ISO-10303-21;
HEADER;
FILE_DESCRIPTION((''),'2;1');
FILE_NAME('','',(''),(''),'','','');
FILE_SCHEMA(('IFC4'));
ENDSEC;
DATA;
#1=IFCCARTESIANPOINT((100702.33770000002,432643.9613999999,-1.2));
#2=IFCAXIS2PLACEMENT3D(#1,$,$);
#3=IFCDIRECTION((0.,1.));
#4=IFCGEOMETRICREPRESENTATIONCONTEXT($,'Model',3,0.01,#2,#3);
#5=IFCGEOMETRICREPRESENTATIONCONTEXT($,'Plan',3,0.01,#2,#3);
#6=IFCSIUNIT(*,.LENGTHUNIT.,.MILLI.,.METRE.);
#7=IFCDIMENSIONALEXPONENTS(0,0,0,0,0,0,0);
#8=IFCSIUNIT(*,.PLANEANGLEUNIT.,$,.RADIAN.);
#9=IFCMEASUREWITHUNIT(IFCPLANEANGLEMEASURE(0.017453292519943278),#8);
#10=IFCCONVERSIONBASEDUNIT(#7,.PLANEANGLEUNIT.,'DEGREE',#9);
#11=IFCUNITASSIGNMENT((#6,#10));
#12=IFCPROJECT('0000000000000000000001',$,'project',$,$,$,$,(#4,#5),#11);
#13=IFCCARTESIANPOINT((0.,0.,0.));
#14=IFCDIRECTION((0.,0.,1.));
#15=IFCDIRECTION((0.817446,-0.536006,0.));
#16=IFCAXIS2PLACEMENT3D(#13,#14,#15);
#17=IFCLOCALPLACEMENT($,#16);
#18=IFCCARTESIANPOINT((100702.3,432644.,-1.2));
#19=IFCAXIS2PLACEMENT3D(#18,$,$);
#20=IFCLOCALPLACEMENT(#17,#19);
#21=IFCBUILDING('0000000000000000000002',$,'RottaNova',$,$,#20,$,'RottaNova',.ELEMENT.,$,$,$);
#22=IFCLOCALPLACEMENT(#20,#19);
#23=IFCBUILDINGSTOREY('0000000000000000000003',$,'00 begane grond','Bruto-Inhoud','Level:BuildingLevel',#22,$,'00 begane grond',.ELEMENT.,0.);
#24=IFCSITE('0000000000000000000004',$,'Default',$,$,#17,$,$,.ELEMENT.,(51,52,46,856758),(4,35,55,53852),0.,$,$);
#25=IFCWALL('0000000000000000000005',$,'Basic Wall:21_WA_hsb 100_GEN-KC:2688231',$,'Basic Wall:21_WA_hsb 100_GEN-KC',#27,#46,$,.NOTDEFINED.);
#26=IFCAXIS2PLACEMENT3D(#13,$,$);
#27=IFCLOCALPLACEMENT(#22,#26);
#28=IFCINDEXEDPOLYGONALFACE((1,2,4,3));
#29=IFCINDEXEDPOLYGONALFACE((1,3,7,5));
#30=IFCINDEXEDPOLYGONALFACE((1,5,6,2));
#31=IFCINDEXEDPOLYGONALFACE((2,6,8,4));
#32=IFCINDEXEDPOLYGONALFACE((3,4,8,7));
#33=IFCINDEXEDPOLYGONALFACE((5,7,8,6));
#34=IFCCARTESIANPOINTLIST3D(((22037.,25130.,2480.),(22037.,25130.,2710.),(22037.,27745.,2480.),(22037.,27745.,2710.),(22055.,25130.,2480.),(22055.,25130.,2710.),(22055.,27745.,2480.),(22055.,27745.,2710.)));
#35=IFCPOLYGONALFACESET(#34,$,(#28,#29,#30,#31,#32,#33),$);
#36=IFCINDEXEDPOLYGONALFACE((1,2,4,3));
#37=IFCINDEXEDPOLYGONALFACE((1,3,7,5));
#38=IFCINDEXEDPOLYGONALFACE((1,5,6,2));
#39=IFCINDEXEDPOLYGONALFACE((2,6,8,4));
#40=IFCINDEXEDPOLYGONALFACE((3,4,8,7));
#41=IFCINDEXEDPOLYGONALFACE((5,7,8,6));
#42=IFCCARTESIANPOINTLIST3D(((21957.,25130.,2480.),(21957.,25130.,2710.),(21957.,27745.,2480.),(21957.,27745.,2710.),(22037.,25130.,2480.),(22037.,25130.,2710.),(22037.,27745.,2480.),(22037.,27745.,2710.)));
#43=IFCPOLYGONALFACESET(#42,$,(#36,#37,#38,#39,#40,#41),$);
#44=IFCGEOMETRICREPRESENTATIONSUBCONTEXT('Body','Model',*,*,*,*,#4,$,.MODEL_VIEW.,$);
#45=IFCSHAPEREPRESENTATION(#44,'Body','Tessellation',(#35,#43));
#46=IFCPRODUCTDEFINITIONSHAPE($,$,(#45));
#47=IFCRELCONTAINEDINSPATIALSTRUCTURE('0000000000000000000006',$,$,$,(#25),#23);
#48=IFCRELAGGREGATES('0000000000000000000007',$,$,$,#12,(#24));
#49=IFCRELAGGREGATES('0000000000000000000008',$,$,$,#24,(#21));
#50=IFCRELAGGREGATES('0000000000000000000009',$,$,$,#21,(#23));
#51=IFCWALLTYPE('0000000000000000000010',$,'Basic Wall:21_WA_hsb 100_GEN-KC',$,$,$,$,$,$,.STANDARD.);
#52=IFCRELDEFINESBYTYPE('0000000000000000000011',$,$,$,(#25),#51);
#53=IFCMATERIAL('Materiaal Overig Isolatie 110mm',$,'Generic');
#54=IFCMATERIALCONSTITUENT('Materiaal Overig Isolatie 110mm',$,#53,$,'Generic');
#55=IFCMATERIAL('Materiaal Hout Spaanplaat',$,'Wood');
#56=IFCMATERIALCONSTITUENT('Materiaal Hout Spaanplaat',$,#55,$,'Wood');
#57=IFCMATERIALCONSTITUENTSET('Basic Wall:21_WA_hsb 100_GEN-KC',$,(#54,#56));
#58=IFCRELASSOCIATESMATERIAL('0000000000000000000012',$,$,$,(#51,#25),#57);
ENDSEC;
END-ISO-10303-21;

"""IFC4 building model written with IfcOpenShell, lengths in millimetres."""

from ifc_helpers import new_model, entity, si_unit, converted_unit, direction, frame, place, context, subcontext, project, spatial, indexed_curve, outline, extrude, material, constituent, constituent_set, type_object, element, save


model = new_model("IFC4")

# Units and contexts
model_context = context("Model", 3, precision=0.01, world=frame((100702.33770000002, 432643.9613999999, -1.2)), true_north=direction((0.0, 1.0)))
plan_context = context("Plan", 3, precision=0.01, world=frame((100702.33770000002, 432643.9613999999, -1.2)), true_north=direction((0.0, 1.0)))
body_context = subcontext(model_context, "Body", "Model", "MODEL_VIEW")
ifc_project = project(units=[si_unit("LENGTHUNIT", "METRE", prefix="MILLI"), converted_unit("PLANEANGLEUNIT", "DEGREE", entity("IfcPlaneAngleMeasure", 0.017453292519943278), si_unit("PLANEANGLEUNIT", "RADIAN"), dimensions=[0, 0, 0, 0, 0, 0, 0])], contexts=[model_context, plan_context])

# Site, building, storey
site_placement = place(None, frame((0.0, 0.0, 0.0), z_axis=(0.0, 0.0, 1.0), x_axis=(0.817446, -0.536006, 0.0)))
site = spatial("IfcSite", under=ifc_project, at=site_placement, Name="Default", CompositionType="ELEMENT", RefLatitude=(51, 52, 46, 856758), RefLongitude=(4, 35, 55, 53852), RefElevation=0.0)
building_placement = place(site_placement, frame((100702.3, 432644.0, -1.2)))
building = spatial("IfcBuilding", under=site, at=building_placement, Name="RottaNova", LongName="RottaNova", CompositionType="ELEMENT")
storey_placement = place(building_placement, frame((100702.3, 432644.0, -1.2)))
storey = spatial("IfcBuildingStorey", under=building, at=storey_placement, Name="00 begane grond", Description="Bruto-Inhoud", ObjectType="Level:BuildingLevel", LongName="00 begane grond", CompositionType="ELEMENT", Elevation=0.0)

# Wall
ifc_material_1 = material(Name="Materiaal Overig Isolatie 110mm", Category="Generic")
ifc_constituent_1 = constituent(ifc_material_1, Name="Materiaal Overig Isolatie 110mm", Category="Generic")
ifc_material_2 = material(Name="Materiaal Hout Spaanplaat", Category="Wood")
ifc_constituent_2 = constituent(ifc_material_2, Name="Materiaal Hout Spaanplaat", Category="Wood")
ifc_constituent_set = constituent_set(constituents=[ifc_constituent_1, ifc_constituent_2], Name="Basic Wall:21_WA_hsb 100_GEN-KC")
wall_type_1 = type_object("IfcWallType", Name="Basic Wall:21_WA_hsb 100_GEN-KC", PredefinedType="STANDARD", material=ifc_constituent_set)
wall_1_placement = place(storey_placement, frame((22006.0, 25130.0, 2480.0), z_axis=(0.0, 0.0, 1.0), x_axis=(0.0, 1.0, 0.0)))
element("IfcWall", 1, at=wall_1_placement, inside=storey, type_object=wall_type_1, material=ifc_constituent_set, Name="Basic Wall:21_WA_hsb 100_GEN-KC:2688231", ObjectType="Basic Wall:21_WA_hsb 100_GEN-KC", PredefinedType="NOTDEFINED", context=body_context, shape_type="SweptSolid", body=[
    extrude(outline(indexed_curve([(-9.0, -1307.5), (9.0, -1307.5), (9.0, 1307.5), (-9.0, 1307.5), (-9.0, -1307.5)], self_intersect=False)), frame((1307.5, -40.0, 0.0), z_axis=(0.0, 0.0, 1.0), x_axis=(0.0, 1.0, 0.0)), (0.0, 0.0, 1.0), 230.0),
    extrude(outline(indexed_curve([(-40.0, -1307.5), (40.0, -1307.5), (40.0, 1307.5), (-40.0, 1307.5), (-40.0, -1307.5)], self_intersect=False)), frame((1307.5, 9.0, 0.0), z_axis=(0.0, 0.0, 1.0), x_axis=(0.0, -1.0, 0.0)), (0.0, 0.0, 1.0), 230.0),
])

save(model, "model.ifc")
